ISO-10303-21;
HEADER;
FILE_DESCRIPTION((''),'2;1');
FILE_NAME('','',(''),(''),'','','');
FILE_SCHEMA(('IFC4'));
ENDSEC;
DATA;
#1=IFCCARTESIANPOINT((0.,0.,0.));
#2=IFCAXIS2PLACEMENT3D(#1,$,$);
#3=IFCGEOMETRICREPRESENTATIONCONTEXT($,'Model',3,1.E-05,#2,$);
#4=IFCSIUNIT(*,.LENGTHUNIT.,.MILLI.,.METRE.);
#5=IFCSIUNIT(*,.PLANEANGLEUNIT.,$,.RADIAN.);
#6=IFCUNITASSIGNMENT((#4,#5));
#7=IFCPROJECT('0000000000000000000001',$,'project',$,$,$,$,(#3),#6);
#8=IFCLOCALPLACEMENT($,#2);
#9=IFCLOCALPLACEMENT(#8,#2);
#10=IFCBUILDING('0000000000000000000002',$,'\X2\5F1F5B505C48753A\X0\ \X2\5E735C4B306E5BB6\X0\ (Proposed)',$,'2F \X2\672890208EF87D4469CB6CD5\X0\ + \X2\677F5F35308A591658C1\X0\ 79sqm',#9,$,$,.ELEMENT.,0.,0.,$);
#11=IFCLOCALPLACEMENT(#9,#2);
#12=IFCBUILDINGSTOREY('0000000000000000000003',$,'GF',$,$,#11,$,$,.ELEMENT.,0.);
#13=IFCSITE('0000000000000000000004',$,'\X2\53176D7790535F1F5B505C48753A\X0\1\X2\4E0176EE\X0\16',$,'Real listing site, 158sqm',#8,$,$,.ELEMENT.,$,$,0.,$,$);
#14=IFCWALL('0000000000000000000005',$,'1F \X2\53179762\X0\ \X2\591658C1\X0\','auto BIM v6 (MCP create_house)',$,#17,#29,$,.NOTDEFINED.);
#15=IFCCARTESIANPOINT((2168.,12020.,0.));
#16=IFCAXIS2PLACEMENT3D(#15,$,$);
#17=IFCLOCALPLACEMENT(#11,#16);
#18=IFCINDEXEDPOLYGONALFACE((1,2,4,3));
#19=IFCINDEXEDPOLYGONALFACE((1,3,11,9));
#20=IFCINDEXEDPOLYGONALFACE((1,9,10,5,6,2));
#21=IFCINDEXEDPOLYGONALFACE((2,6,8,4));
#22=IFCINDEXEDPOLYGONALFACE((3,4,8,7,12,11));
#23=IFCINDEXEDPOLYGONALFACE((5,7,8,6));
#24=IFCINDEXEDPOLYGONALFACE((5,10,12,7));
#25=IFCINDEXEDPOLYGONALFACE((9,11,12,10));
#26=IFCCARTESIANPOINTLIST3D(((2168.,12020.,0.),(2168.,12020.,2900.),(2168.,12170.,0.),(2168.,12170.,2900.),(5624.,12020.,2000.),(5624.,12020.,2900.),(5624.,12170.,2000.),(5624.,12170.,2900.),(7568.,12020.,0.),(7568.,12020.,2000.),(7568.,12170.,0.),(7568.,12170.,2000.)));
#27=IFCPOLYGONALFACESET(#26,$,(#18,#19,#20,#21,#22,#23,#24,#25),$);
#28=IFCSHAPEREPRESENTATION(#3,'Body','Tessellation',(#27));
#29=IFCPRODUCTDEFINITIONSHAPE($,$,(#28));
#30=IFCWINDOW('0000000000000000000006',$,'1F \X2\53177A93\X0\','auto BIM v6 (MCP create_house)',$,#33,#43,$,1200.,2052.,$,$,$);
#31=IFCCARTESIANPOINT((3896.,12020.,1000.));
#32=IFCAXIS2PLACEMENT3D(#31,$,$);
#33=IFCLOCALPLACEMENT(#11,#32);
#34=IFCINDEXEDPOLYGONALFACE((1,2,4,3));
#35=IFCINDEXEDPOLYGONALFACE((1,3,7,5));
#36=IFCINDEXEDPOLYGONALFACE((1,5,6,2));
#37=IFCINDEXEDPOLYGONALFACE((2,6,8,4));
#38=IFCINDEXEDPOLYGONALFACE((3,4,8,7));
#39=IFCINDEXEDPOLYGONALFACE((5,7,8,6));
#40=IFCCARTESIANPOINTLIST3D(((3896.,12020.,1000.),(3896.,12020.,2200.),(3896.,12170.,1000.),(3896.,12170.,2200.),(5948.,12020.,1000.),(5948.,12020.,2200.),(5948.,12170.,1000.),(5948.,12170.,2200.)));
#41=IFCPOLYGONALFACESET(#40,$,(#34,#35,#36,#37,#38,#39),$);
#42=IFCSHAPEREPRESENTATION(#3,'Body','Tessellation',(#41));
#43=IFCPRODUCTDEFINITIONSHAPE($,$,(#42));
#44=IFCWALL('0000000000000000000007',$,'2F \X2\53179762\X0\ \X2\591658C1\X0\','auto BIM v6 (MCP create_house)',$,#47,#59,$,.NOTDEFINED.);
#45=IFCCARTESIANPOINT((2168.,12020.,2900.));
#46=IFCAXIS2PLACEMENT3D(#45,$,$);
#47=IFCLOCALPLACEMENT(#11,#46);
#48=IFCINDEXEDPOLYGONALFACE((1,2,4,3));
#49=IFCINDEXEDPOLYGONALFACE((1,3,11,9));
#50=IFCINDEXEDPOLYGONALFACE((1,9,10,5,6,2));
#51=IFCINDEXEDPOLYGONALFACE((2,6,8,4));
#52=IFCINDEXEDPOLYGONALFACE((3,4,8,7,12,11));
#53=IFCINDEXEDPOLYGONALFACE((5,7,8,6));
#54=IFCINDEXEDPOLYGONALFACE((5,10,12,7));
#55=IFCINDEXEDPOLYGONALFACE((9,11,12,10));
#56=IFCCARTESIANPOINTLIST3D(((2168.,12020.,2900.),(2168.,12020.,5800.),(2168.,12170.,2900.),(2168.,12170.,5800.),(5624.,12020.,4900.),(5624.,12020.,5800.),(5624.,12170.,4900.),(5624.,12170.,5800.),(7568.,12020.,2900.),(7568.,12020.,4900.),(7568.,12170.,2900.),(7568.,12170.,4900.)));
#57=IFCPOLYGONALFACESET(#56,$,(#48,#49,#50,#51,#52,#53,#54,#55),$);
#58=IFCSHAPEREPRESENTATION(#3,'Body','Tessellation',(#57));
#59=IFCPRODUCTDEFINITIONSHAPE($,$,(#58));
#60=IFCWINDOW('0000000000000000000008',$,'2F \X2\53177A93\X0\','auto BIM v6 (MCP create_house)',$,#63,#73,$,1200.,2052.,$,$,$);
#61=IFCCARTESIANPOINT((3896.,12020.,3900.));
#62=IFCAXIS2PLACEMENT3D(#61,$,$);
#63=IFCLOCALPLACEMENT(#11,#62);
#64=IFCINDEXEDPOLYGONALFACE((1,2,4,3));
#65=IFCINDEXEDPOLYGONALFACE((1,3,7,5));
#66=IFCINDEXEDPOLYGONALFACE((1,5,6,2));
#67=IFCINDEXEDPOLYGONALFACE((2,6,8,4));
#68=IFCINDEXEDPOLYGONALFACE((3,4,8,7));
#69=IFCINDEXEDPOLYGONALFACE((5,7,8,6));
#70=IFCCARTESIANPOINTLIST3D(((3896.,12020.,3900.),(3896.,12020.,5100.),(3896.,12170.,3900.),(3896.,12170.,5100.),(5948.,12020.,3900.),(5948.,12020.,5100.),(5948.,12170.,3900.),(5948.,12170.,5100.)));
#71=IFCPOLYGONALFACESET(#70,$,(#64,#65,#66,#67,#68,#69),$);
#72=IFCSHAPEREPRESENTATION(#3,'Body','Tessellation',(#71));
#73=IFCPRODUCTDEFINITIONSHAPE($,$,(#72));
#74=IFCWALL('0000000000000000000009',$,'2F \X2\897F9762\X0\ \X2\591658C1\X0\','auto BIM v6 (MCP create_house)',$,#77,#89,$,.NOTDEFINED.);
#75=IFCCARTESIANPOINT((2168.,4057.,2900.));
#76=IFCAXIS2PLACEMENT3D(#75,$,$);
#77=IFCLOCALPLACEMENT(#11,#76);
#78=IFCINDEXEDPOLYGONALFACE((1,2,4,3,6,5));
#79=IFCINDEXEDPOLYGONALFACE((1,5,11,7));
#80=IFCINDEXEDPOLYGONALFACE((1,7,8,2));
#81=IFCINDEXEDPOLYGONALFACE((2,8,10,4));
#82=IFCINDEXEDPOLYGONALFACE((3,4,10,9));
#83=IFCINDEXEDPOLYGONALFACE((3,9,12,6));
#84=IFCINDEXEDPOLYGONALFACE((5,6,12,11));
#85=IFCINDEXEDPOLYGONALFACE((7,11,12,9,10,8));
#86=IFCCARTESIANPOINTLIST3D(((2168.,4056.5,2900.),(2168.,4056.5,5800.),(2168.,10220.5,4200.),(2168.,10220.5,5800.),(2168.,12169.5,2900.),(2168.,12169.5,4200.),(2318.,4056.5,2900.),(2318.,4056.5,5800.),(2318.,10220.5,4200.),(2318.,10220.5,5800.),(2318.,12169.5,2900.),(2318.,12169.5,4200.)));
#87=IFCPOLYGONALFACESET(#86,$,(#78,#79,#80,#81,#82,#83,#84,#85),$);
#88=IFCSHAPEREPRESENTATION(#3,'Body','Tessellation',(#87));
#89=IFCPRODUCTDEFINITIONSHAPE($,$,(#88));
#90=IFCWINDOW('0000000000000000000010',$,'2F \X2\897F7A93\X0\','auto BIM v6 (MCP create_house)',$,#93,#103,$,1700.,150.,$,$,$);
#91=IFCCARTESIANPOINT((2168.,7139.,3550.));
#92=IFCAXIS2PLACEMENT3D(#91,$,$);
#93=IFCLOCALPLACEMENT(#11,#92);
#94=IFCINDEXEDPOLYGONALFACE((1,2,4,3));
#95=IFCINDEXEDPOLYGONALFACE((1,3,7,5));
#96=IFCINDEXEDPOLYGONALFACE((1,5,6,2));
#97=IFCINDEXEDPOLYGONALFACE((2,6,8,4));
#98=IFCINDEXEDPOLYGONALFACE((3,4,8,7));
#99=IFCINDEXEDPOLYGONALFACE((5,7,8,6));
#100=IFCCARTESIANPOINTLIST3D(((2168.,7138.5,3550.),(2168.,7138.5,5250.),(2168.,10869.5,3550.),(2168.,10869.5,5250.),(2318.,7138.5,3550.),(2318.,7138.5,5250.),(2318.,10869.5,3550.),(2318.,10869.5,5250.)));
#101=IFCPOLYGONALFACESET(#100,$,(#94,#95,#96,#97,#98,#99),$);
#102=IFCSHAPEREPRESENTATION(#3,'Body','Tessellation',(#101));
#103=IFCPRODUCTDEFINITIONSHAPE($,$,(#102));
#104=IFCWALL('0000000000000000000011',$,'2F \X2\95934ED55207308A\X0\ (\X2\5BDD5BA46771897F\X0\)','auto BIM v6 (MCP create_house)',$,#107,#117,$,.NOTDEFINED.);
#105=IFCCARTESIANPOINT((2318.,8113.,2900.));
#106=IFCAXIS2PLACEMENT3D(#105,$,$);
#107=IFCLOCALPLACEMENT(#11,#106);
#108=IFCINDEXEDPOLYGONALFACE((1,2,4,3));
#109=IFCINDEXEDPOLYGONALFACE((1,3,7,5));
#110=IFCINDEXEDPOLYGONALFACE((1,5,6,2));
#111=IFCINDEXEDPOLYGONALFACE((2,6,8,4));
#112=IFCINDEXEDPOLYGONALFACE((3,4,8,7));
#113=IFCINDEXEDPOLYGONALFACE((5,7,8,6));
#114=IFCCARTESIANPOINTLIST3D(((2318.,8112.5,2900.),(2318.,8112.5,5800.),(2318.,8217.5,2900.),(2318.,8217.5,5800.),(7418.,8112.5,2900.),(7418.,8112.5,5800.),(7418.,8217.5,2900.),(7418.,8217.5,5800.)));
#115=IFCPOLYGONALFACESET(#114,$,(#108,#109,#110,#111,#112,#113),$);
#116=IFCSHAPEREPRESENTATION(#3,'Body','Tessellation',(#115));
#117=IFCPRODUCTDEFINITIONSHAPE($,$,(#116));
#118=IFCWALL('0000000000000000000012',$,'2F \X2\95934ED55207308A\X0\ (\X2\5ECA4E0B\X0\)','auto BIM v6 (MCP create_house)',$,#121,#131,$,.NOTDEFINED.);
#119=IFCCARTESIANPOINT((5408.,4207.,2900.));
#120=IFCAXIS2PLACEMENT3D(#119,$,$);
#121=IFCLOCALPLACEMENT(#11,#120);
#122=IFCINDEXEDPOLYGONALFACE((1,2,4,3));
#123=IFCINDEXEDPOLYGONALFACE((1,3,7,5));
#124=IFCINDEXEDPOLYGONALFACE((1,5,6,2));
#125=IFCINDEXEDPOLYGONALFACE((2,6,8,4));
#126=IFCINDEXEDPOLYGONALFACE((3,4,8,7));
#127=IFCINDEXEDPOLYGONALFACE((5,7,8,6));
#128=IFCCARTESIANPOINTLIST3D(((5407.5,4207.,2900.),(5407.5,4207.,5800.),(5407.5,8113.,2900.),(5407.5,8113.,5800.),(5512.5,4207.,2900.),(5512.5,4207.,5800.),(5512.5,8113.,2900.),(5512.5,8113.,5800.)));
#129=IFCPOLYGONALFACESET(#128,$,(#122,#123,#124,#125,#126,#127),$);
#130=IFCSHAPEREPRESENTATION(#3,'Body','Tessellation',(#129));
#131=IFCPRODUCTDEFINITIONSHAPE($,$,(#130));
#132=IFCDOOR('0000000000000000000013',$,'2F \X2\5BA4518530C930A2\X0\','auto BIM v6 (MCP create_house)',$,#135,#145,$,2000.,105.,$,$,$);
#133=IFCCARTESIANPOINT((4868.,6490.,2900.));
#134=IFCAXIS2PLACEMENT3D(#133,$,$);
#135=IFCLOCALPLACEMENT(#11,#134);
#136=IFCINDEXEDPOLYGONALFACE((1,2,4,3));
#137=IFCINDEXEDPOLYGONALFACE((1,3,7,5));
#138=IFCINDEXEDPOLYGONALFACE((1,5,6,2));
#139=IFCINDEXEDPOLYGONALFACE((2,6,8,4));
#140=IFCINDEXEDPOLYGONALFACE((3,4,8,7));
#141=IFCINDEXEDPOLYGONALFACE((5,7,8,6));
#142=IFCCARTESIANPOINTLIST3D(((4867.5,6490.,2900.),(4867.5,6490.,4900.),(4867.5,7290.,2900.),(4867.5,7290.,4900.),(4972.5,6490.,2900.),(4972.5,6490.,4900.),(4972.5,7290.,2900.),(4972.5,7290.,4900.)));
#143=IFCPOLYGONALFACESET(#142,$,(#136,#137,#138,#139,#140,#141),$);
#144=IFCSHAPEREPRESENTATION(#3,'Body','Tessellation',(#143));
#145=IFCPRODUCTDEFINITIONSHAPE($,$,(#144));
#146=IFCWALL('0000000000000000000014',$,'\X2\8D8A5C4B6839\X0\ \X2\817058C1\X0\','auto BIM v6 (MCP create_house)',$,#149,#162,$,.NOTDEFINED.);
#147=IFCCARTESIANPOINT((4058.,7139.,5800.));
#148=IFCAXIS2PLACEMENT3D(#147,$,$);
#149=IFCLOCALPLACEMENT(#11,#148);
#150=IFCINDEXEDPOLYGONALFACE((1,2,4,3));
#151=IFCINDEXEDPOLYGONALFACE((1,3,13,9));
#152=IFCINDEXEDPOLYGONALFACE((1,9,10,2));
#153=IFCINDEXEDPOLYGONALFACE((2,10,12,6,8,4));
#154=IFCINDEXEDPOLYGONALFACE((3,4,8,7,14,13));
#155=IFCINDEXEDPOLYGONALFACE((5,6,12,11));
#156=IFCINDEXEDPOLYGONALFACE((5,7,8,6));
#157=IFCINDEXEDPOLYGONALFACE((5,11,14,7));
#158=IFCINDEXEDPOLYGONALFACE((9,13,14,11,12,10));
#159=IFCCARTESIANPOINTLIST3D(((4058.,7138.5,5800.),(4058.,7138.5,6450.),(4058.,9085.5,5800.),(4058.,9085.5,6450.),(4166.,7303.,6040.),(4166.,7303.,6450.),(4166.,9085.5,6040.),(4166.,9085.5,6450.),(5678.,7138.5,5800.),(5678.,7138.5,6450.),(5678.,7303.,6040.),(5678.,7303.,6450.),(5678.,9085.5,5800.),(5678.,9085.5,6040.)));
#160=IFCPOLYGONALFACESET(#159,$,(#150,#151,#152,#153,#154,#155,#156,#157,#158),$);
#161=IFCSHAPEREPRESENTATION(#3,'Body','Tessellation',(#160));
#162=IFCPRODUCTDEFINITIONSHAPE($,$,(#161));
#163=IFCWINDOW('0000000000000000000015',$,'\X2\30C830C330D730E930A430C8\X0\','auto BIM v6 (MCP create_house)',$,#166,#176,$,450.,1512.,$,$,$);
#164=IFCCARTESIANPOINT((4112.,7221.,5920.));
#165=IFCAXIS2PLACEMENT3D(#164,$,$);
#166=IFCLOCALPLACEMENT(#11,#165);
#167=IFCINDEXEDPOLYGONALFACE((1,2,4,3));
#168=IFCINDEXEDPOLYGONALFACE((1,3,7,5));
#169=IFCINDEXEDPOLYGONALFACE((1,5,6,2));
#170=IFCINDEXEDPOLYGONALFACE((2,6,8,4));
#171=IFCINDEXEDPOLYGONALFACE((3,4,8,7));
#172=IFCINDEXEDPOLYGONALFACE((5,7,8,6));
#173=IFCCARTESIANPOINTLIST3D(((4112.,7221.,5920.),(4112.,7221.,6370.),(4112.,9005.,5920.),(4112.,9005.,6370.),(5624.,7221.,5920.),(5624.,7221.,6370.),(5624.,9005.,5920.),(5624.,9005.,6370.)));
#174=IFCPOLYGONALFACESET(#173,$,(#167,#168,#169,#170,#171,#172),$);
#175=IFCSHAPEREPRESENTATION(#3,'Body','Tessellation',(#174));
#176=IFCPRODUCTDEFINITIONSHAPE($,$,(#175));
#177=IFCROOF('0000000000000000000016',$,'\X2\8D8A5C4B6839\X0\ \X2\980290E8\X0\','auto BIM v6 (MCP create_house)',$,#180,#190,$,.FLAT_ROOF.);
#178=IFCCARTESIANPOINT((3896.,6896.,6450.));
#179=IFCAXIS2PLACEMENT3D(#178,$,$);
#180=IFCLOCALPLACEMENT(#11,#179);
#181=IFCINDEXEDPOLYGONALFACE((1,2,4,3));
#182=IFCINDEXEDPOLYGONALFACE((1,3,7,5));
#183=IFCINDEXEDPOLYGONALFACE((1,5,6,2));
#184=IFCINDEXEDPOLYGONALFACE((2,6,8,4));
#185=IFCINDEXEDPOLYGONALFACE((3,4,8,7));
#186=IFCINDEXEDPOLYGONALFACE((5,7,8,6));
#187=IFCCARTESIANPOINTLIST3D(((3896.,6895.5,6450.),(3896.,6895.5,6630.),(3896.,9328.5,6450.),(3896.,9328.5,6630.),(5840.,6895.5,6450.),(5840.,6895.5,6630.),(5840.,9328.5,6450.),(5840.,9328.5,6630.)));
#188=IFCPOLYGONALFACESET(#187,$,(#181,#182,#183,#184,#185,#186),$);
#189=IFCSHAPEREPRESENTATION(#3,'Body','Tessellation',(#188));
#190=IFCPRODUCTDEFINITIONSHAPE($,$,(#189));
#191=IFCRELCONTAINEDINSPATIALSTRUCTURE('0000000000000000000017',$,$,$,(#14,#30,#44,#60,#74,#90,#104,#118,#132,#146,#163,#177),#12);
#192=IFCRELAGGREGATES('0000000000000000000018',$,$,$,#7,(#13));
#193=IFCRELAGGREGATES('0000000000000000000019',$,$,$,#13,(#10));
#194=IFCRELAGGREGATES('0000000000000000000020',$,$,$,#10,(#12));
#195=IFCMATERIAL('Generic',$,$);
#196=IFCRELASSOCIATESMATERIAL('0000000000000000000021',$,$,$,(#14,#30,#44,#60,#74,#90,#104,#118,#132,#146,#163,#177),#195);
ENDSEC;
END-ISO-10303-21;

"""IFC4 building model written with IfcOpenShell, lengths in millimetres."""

from ifc_helpers import new_model, si_unit, frame, frame_2d, origin, place, context, project, spatial, rectangle, extrude, material, element, fill, save


model = new_model("IFC4")

# Units and contexts
model_context = context("Model", 3, precision=1e-05, world=origin())
ifc_project = project(units=[si_unit("LENGTHUNIT", "METRE", prefix="MILLI"), si_unit("PLANEANGLEUNIT", "RADIAN")], contexts=[model_context])

# Site, building, storey
site_placement = place(None, origin())
site = spatial("IfcSite", under=ifc_project, at=site_placement, Name="北海道弟子屈町1丁目16", ObjectType="Real listing site, 158sqm", CompositionType="ELEMENT", RefElevation=0.0)
building_placement = place(site_placement, origin())
building = spatial("IfcBuilding", under=site, at=building_placement, Name="弟子屈町 平屋の家 (Proposed)", ObjectType="2F 木造軸組構法 + 板張り外壁 79sqm", CompositionType="ELEMENT", ElevationOfRefHeight=0.0, ElevationOfTerrain=0.0)
storey_placement = place(building_placement, origin())
storey = spatial("IfcBuildingStorey", under=building, at=storey_placement, Name="GF", CompositionType="ELEMENT", Elevation=0.0)

# Wall, opening, window
ifc_material = material(Name="Generic")
wall_1_placement = place(storey_placement, frame((2168.0, 12020.0, 0.0)))
wall_1 = element("IfcWall", 1, at=wall_1_placement, inside=storey, material=ifc_material, Name="1F 北面 外壁", Description="auto BIM v6 (MCP create_house)", PredefinedType="NOTDEFINED", context=model_context, shape_type="SweptSolid", body=[
    extrude(rectangle(XDim=5400.0, YDim=150.0, at=frame_2d((2700.0, 75.0))), frame((2168.0, 12020.0, 0.0)), (0.0, 0.0, 1.0), 2900.0),
])
opening_1_placement = place(storey_placement, frame((3896.0, 12020.0, 1000.0)))
opening_1 = element("IfcOpeningElement", 2, at=opening_1_placement, cuts=wall_1, PredefinedType="NOTDEFINED", context=model_context, shape_type="SweptSolid", body=[
    extrude(rectangle(XDim=2052.0, YDim=150.0, at=frame_2d((1026.0, 75.0))), frame((3896.0, 12020.0, 1000.0)), (0.0, 0.0, 1.0), 1200.0),
])
window_1_placement = place(storey_placement, frame((3896.0, 12020.0, 1000.0)))
window_1 = element("IfcWindow", 3, at=window_1_placement, inside=storey, material=ifc_material, Name="1F 北窓", Description="auto BIM v6 (MCP create_house)", OverallHeight=1200.0, OverallWidth=2052.0, context=model_context, shape_type="SweptSolid", body=[
    extrude(rectangle(XDim=2052.0, YDim=150.0, at=frame_2d((1026.0, 75.0))), frame((3896.0, 12020.0, 1000.0)), (0.0, 0.0, 1.0), 1200.0),
])
fill(opening_1, window_1)

# Walls, openings, windows
wall_2_placement = place(storey_placement, frame((2168.0, 12020.0, 2900.0)))
wall_2 = element("IfcWall", 4, at=wall_2_placement, inside=storey, material=ifc_material, Name="2F 北面 外壁", Description="auto BIM v6 (MCP create_house)", PredefinedType="NOTDEFINED", context=model_context, shape_type="SweptSolid", body=[
    extrude(rectangle(XDim=5400.0, YDim=150.0, at=frame_2d((2700.0, 75.0))), frame((2168.0, 12020.0, 2900.0)), (0.0, 0.0, 1.0), 2900.0),
])
opening_2_placement = place(storey_placement, frame((3896.0, 12020.0, 3900.0)))
opening_2 = element("IfcOpeningElement", 5, at=opening_2_placement, cuts=wall_2, PredefinedType="NOTDEFINED", context=model_context, shape_type="SweptSolid", body=[
    extrude(rectangle(XDim=2052.0, YDim=150.0, at=frame_2d((1026.0, 75.0))), frame((3896.0, 12020.0, 3900.0)), (0.0, 0.0, 1.0), 1200.0),
])
window_2_placement = place(storey_placement, frame((3896.0, 12020.0, 3900.0)))
window_2 = element("IfcWindow", 6, at=window_2_placement, inside=storey, material=ifc_material, Name="2F 北窓", Description="auto BIM v6 (MCP create_house)", OverallHeight=1200.0, OverallWidth=2052.0, context=model_context, shape_type="SweptSolid", body=[
    extrude(rectangle(XDim=2052.0, YDim=150.0, at=frame_2d((1026.0, 75.0))), frame((3896.0, 12020.0, 3900.0)), (0.0, 0.0, 1.0), 1200.0),
])
fill(opening_2, window_2)
wall_3_placement = place(storey_placement, frame((2168.0, 4057.0, 2900.0)))
wall_3 = element("IfcWall", 7, at=wall_3_placement, inside=storey, material=ifc_material, Name="2F 西面 外壁", Description="auto BIM v6 (MCP create_house)", PredefinedType="NOTDEFINED", context=model_context, shape_type="SweptSolid", body=[
    extrude(rectangle(XDim=150.0, YDim=8113.0, at=frame_2d((75.0, 4056.0))), frame((2168.0, 4057.0, 2900.0)), (0.0, 0.0, 1.0), 2900.0),
])
opening_3_placement = place(storey_placement, frame((2168.0, 7139.0, 3550.0)))
opening_3 = element("IfcOpeningElement", 8, at=opening_3_placement, cuts=wall_3, PredefinedType="NOTDEFINED", context=model_context, shape_type="SweptSolid", body=[
    extrude(rectangle(XDim=150.0, YDim=3731.0, at=frame_2d((75.0, 1865.0))), frame((2168.0, 7139.0, 3550.0)), (0.0, 0.0, 1.0), 1700.0),
])
window_3_placement = place(storey_placement, frame((2168.0, 7139.0, 3550.0)))
window_3 = element("IfcWindow", 9, at=window_3_placement, inside=storey, material=ifc_material, Name="2F 西窓", Description="auto BIM v6 (MCP create_house)", OverallHeight=1700.0, OverallWidth=150.0, context=model_context, shape_type="SweptSolid", body=[
    extrude(rectangle(XDim=150.0, YDim=3731.0, at=frame_2d((75.0, 1865.0))), frame((2168.0, 7139.0, 3550.0)), (0.0, 0.0, 1.0), 1700.0),
])
fill(opening_3, window_3)

# Walls
wall_4_placement = place(storey_placement, frame((2318.0, 8113.0, 2900.0)))
element("IfcWall", 10, at=wall_4_placement, inside=storey, material=ifc_material, Name="2F 間仕切り (寝室東西)", Description="auto BIM v6 (MCP create_house)", PredefinedType="NOTDEFINED", context=model_context, shape_type="SweptSolid", body=[
    extrude(rectangle(XDim=5100.0, YDim=105.0, at=frame_2d((2550.0, 52.0))), frame((2318.0, 8113.0, 2900.0)), (0.0, 0.0, 1.0), 2900.0),
])
wall_5_placement = place(storey_placement, frame((5408.0, 4207.0, 2900.0)))
element("IfcWall", 11, at=wall_5_placement, inside=storey, material=ifc_material, Name="2F 間仕切り (廊下)", Description="auto BIM v6 (MCP create_house)", PredefinedType="NOTDEFINED", context=model_context, shape_type="SweptSolid", body=[
    extrude(rectangle(XDim=105.0, YDim=3906.0, at=frame_2d((52.0, 1953.0))), frame((5408.0, 4207.0, 2900.0)), (0.0, 0.0, 1.0), 2900.0),
])

# Door
door_placement = place(storey_placement, frame((4868.0, 6490.0, 2900.0)))
element("IfcDoor", 12, at=door_placement, inside=storey, material=ifc_material, Name="2F 室内ドア", Description="auto BIM v6 (MCP create_house)", OverallHeight=2000.0, OverallWidth=105.0, context=model_context, shape_type="SweptSolid", body=[
    extrude(rectangle(XDim=105.0, YDim=800.0, at=frame_2d((52.0, 400.0))), frame((4868.0, 6490.0, 2900.0)), (0.0, 0.0, 1.0), 2000.0),
])

# Wall, opening, window
wall_6_placement = place(storey_placement, frame((4058.0, 7139.0, 5800.0)))
wall_6 = element("IfcWall", 13, at=wall_6_placement, inside=storey, material=ifc_material, Name="越屋根 腰壁", Description="auto BIM v6 (MCP create_house)", PredefinedType="NOTDEFINED", context=model_context, shape_type="SweptSolid", body=[
    extrude(rectangle(XDim=1620.0, YDim=1947.0, at=frame_2d((810.0, 973.0))), frame((4058.0, 7139.0, 5800.0)), (0.0, 0.0, 1.0), 650.0),
])
opening_4_placement = place(storey_placement, frame((4112.0, 7221.0, 5920.0)))
opening_4 = element("IfcOpeningElement", 14, at=opening_4_placement, cuts=wall_6, PredefinedType="NOTDEFINED", context=model_context, shape_type="SweptSolid", body=[
    extrude(rectangle(XDim=1512.0, YDim=1784.0, at=frame_2d((756.0, 892.0))), frame((4112.0, 7221.0, 5920.0)), (0.0, 0.0, 1.0), 450.0),
])
window_4_placement = place(storey_placement, frame((4112.0, 7221.0, 5920.0)))
window_4 = element("IfcWindow", 15, at=window_4_placement, inside=storey, material=ifc_material, Name="トップライト", Description="auto BIM v6 (MCP create_house)", OverallHeight=450.0, OverallWidth=1512.0, context=model_context, shape_type="SweptSolid", body=[
    extrude(rectangle(XDim=1512.0, YDim=1784.0, at=frame_2d((756.0, 892.0))), frame((4112.0, 7221.0, 5920.0)), (0.0, 0.0, 1.0), 450.0),
])
fill(opening_4, window_4)

# Roof
roof_placement = place(storey_placement, frame((3896.0, 6896.0, 6450.0)))
element("IfcRoof", 16, at=roof_placement, inside=storey, material=ifc_material, Name="越屋根 頂部", Description="auto BIM v6 (MCP create_house)", PredefinedType="FLAT_ROOF", context=model_context, shape_type="SweptSolid", body=[
    extrude(rectangle(XDim=1944.0, YDim=2433.0, at=frame_2d((972.0, 1216.0))), frame((3896.0, 6896.0, 6450.0)), (0.0, 0.0, 1.0), 180.0),
])

save(model, "model.ifc")
